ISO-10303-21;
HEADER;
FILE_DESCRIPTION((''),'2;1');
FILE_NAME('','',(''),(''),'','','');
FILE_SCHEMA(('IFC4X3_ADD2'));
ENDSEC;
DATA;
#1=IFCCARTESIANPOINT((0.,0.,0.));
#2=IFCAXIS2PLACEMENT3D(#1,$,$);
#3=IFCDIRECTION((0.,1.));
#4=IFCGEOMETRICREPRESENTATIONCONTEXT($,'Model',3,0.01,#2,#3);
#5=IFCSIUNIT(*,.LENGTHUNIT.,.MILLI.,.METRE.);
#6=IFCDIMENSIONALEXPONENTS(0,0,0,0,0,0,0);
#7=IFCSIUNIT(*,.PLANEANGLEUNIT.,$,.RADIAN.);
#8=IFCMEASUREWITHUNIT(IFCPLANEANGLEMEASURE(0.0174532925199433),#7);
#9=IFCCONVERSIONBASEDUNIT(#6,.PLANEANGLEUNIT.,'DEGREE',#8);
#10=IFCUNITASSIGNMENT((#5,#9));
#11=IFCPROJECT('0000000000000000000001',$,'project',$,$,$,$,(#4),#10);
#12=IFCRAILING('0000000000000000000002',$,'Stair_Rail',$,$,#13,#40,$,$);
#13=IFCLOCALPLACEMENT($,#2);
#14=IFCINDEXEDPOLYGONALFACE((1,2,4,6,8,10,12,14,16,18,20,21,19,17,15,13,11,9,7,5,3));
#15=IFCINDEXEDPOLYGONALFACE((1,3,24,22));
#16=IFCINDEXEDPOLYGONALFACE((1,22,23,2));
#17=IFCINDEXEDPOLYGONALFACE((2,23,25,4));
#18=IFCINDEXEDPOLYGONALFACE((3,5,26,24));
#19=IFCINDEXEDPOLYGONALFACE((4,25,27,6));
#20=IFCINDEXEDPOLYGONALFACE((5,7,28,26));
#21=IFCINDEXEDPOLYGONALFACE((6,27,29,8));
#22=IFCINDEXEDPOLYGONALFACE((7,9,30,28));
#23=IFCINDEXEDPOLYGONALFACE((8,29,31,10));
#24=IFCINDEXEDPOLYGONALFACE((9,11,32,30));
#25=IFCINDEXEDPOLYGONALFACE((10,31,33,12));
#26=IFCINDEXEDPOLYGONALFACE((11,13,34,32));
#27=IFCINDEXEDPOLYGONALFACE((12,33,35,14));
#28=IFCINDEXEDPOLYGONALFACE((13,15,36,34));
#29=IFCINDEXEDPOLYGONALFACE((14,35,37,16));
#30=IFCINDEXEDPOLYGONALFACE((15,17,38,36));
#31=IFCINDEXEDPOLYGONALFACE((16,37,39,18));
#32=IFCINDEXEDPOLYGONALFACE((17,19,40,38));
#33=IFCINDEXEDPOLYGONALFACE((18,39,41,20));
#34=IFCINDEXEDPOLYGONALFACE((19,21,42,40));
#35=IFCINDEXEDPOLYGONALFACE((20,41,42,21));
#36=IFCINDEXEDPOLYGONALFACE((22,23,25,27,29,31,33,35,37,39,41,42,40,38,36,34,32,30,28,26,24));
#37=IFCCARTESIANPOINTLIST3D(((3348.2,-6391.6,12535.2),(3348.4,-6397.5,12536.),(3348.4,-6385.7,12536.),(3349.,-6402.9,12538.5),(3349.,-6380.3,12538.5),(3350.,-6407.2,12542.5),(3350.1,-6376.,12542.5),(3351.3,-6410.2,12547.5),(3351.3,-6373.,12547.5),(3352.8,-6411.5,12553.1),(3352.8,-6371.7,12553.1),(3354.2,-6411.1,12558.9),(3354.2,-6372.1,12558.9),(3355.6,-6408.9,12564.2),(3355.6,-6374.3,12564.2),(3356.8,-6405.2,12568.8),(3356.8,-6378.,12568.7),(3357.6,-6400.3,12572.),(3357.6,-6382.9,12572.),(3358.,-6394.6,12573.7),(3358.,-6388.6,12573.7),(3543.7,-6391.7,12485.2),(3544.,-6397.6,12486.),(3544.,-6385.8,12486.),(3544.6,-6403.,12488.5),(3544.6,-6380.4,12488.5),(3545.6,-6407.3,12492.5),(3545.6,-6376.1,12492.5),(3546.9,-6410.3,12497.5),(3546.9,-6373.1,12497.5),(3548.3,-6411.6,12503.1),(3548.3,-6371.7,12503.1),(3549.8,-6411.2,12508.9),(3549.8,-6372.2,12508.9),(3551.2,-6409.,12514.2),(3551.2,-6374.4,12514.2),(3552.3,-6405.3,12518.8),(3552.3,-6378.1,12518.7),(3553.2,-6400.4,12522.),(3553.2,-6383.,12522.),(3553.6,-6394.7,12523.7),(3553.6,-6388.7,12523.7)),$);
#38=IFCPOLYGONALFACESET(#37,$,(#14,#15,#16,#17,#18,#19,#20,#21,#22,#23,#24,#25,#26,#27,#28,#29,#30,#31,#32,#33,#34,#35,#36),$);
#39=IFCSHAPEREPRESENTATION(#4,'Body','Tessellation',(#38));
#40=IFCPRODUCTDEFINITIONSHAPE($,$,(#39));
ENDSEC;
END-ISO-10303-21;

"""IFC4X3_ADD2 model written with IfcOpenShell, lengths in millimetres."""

from ifc_helpers import new_model, entity, si_unit, converted_unit, direction, origin, context, project, element, save


model = new_model("IFC4X3_ADD2")

# Units and contexts
model_context = context("Model", 3, precision=0.01, world=origin(), true_north=direction((0.0, 1.0)))
ifc_project = project(units=[si_unit("LENGTHUNIT", "METRE", prefix="MILLI"), converted_unit("PLANEANGLEUNIT", "DEGREE", entity("IfcPlaneAngleMeasure", 0.0174532925199433), si_unit("PLANEANGLEUNIT", "RADIAN"), dimensions=[0, 0, 0, 0, 0, 0, 0])], contexts=[model_context])

# Railing
element("IfcRailing", 1, Name="Stair_Rail", context=model_context, shape_type="SweptSolid", body=[
    entity("IfcSweptDiskSolid", entity("IfcPolyline", [entity("IfcCartesianPoint", [3548.7, -6391.7, 12504.5]), entity("IfcCartesianPoint", [3353.1, -6391.6, 12554.5])]), 20.0),
])

save(model, "model.ifc")
